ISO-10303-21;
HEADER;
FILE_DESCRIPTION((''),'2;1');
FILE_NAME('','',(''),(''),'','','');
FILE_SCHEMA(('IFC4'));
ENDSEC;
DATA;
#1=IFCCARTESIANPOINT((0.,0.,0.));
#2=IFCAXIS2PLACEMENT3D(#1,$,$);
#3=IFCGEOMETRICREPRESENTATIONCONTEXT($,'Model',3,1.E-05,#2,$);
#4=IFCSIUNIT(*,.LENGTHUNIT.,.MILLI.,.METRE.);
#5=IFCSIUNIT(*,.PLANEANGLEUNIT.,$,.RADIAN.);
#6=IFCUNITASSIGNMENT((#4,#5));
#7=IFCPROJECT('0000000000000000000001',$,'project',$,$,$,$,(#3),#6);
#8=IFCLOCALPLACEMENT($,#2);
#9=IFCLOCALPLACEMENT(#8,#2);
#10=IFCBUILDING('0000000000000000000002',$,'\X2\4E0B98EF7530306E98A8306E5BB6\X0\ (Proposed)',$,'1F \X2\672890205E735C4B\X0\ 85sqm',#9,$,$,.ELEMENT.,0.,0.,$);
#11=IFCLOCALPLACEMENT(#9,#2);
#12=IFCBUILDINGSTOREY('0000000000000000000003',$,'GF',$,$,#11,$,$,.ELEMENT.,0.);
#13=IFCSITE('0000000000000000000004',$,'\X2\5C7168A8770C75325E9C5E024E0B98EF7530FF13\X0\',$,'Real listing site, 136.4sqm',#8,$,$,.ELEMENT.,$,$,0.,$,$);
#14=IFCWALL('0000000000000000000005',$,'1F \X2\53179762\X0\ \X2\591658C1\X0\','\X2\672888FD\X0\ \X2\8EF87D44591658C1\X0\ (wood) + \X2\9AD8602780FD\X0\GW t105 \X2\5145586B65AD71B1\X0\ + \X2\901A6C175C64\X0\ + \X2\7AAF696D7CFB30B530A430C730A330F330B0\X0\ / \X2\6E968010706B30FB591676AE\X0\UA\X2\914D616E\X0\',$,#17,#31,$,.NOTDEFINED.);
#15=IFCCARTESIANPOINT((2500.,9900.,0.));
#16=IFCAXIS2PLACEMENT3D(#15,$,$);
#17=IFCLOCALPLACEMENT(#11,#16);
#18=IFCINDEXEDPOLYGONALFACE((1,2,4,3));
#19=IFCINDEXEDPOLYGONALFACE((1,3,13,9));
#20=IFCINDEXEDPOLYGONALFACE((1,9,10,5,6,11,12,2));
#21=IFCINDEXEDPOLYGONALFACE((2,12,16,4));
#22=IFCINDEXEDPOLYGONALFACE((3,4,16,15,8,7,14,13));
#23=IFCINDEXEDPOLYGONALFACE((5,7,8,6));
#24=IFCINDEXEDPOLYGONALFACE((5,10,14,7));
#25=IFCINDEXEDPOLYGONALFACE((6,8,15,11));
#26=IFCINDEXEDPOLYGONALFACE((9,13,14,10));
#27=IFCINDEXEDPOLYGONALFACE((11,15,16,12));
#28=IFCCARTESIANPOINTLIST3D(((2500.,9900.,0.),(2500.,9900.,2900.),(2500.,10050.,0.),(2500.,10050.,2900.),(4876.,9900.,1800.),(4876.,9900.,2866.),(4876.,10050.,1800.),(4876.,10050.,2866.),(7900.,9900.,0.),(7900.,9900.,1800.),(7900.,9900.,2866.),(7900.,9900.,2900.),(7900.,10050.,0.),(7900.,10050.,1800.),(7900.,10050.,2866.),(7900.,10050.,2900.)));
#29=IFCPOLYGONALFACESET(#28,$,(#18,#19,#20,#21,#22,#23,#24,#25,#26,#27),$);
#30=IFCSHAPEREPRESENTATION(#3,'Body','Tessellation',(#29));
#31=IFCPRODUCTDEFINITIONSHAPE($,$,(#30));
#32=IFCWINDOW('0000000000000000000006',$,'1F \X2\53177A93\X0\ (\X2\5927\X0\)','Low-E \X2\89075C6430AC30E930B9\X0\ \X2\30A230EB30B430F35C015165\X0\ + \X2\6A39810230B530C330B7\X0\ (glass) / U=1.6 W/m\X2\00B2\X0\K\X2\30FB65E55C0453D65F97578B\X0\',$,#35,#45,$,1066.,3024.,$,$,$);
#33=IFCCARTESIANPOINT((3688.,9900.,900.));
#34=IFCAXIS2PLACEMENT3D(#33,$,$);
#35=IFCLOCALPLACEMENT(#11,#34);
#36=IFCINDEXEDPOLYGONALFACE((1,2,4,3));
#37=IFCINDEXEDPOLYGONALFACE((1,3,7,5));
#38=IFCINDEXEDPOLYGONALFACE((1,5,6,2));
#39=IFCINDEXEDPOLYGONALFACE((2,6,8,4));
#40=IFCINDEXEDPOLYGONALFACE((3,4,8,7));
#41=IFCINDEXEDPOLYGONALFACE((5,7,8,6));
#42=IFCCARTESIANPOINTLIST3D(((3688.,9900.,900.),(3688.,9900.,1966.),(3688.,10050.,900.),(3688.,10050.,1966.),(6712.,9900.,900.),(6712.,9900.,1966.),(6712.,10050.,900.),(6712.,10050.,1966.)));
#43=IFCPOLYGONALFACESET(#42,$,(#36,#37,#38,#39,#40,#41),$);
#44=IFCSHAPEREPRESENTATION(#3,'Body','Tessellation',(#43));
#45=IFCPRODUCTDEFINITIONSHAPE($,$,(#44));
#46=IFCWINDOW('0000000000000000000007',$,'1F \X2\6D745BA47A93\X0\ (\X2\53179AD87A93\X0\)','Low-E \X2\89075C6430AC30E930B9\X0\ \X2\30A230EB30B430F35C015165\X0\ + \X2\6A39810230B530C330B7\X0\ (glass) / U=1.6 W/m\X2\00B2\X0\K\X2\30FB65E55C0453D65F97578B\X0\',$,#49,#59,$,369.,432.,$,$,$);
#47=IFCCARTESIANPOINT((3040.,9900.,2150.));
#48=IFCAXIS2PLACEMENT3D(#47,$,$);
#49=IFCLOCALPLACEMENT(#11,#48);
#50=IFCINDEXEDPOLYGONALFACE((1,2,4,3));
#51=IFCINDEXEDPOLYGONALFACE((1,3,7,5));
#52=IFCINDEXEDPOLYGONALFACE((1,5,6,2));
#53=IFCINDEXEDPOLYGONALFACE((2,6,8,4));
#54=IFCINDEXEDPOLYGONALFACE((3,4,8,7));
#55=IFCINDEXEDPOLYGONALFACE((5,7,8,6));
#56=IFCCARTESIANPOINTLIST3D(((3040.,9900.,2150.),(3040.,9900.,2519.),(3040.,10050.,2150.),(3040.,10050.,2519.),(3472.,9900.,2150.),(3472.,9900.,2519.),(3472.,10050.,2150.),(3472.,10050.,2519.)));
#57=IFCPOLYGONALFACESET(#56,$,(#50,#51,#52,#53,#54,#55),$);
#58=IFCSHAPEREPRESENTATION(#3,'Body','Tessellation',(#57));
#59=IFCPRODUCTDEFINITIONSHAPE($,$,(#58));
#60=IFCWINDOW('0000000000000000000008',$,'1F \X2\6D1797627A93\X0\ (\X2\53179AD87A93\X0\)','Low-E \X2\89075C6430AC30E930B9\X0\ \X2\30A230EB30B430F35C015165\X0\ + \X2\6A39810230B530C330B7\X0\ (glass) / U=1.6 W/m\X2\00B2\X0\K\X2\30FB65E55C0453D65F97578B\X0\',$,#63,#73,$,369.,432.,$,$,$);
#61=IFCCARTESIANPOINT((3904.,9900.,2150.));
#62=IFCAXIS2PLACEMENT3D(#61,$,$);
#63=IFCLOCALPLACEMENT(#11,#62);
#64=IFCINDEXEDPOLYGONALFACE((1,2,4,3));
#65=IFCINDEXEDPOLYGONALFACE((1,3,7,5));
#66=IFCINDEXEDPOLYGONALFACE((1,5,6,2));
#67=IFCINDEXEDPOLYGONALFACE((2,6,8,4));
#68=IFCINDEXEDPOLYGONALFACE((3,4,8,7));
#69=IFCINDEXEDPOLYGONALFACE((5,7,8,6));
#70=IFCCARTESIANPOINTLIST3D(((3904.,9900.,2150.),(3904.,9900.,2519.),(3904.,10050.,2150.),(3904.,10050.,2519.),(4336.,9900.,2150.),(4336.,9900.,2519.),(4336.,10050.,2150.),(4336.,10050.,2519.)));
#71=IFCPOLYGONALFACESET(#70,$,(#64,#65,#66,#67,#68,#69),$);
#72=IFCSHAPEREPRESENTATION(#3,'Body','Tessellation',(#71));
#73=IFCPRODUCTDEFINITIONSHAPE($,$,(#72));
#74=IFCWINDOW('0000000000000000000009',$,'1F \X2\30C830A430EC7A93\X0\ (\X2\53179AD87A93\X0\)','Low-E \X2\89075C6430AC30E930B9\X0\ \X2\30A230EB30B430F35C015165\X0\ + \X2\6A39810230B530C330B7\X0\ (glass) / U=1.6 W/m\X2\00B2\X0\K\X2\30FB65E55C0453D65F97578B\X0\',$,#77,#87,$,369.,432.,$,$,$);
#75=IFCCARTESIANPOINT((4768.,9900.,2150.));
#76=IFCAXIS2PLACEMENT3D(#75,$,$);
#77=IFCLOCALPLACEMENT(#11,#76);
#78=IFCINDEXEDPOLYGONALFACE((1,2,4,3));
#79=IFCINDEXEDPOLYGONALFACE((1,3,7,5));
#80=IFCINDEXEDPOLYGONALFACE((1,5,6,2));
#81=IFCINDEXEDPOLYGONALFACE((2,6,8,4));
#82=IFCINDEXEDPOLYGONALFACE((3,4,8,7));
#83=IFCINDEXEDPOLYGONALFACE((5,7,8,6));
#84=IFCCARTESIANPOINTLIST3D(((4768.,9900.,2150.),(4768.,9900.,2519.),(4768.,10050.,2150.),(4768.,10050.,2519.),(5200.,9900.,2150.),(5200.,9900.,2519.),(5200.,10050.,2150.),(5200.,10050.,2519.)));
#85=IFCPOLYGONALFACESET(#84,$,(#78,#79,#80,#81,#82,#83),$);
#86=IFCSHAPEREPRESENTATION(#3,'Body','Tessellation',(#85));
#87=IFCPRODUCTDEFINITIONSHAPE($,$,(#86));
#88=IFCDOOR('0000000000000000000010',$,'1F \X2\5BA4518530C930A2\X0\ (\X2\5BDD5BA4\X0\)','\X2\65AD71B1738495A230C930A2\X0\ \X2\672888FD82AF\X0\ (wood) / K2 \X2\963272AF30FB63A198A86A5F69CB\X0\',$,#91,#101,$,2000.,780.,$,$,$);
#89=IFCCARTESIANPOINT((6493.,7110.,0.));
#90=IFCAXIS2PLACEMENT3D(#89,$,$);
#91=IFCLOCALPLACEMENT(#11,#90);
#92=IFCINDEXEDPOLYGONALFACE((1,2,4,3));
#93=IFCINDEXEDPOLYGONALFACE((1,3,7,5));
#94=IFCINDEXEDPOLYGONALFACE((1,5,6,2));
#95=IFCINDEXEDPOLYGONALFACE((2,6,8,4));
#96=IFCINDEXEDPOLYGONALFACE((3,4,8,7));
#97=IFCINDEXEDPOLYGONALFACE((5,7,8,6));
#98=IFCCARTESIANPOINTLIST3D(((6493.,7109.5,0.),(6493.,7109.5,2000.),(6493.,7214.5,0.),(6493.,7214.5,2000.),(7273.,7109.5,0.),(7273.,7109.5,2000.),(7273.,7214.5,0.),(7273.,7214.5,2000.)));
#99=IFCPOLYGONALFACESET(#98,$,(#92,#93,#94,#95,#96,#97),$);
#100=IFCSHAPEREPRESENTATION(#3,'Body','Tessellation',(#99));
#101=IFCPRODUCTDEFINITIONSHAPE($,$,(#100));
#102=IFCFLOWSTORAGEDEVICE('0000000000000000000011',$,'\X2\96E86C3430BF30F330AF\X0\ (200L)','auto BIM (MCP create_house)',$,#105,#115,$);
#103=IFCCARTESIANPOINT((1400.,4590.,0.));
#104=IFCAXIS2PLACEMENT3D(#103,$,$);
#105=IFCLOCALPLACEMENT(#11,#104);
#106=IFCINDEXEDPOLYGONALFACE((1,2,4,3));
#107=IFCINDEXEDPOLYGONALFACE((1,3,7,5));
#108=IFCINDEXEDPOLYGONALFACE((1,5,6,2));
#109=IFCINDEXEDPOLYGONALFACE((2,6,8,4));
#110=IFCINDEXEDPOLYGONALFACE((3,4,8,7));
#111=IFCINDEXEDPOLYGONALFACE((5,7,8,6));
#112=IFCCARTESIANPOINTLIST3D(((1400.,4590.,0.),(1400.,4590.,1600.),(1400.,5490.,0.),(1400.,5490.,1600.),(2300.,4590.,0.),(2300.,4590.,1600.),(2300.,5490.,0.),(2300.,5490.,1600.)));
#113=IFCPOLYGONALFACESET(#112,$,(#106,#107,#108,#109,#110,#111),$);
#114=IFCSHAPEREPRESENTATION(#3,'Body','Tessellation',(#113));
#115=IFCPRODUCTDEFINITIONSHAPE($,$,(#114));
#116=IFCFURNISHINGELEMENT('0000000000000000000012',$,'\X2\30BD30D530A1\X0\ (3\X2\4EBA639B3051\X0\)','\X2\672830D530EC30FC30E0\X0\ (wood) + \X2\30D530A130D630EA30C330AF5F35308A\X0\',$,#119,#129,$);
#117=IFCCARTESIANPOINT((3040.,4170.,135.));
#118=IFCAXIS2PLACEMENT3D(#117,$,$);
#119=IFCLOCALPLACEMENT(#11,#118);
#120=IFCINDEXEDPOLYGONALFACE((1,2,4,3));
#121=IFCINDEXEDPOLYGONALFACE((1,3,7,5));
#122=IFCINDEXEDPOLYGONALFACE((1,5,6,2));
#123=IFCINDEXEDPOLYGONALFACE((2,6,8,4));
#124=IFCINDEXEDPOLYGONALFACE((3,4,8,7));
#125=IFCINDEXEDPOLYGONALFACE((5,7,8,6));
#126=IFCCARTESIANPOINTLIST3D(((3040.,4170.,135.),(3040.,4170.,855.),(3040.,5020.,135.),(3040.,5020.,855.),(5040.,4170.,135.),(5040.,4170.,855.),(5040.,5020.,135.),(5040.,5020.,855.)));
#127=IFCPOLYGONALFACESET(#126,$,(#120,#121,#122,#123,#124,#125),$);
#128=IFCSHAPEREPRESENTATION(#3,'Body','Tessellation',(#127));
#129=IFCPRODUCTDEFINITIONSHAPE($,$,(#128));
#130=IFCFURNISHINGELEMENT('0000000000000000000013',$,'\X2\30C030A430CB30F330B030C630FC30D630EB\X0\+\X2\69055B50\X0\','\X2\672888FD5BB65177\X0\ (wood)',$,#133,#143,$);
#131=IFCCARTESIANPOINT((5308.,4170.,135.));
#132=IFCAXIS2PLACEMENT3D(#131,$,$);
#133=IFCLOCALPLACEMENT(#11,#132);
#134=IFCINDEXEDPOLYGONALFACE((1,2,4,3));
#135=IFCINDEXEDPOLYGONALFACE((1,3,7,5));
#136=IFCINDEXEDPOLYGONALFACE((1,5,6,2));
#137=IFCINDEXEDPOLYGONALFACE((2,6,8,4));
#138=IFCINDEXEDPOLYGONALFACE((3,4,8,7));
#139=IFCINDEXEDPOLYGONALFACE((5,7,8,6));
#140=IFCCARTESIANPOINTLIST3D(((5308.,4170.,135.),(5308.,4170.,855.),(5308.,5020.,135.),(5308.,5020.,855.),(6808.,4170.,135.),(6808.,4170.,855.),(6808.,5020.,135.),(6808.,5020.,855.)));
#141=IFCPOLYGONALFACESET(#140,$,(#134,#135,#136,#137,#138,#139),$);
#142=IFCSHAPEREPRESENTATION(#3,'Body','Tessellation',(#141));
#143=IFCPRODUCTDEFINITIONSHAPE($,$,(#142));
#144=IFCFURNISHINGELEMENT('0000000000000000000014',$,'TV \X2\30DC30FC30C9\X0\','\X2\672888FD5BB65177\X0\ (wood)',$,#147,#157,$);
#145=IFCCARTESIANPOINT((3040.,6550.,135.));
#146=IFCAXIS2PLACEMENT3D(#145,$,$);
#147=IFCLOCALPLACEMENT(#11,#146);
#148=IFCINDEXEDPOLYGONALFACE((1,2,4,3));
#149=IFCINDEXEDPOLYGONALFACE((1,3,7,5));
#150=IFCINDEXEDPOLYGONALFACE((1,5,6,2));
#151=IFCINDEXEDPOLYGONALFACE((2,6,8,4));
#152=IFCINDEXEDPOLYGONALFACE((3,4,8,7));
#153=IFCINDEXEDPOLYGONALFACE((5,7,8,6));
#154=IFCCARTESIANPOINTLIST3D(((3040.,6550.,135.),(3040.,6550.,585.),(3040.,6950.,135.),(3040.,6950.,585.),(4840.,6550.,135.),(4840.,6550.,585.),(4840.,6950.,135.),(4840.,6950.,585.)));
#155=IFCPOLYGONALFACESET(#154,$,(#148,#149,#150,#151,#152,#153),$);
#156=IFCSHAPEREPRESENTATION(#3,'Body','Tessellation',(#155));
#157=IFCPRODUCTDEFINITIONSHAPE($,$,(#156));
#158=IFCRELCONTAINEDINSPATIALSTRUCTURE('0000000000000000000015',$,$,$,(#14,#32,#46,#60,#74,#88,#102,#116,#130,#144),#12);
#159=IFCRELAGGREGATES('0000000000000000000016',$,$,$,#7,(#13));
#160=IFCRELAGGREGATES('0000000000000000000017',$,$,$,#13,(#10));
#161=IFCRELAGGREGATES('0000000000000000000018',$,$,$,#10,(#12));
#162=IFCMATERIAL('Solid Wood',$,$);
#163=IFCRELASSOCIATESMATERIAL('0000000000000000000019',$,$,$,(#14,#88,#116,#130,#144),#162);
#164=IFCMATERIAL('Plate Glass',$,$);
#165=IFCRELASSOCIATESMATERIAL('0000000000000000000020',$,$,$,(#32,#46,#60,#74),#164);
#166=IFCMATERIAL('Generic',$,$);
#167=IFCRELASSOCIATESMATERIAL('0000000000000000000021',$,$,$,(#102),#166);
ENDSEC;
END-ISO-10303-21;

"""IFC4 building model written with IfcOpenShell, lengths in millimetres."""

from ifc_helpers import new_model, si_unit, frame, frame_2d, origin, place, context, project, spatial, rectangle, extrude, material, element, fill, save


model = new_model("IFC4")

# Units and contexts
model_context = context("Model", 3, precision=1e-05, world=origin())
ifc_project = project(units=[si_unit("LENGTHUNIT", "METRE", prefix="MILLI"), si_unit("PLANEANGLEUNIT", "RADIAN")], contexts=[model_context])

# Site, building, storey
site_placement = place(None, origin())
site = spatial("IfcSite", under=ifc_project, at=site_placement, Name="山梨県甲府市下飯田３", ObjectType="Real listing site, 136.4sqm", CompositionType="ELEMENT", RefElevation=0.0)
building_placement = place(site_placement, origin())
building = spatial("IfcBuilding", under=site, at=building_placement, Name="下飯田の風の家 (Proposed)", ObjectType="1F 木造平屋 85sqm", CompositionType="ELEMENT", ElevationOfRefHeight=0.0, ElevationOfTerrain=0.0)
storey_placement = place(building_placement, origin())
storey = spatial("IfcBuildingStorey", under=building, at=storey_placement, Name="GF", CompositionType="ELEMENT", Elevation=0.0)

# Wall, openings, windows
ifc_material_1 = material(Name="Solid Wood")
wall_1_placement = place(storey_placement, frame((2500.0, 9900.0, 0.0)))
wall_1 = element("IfcWall", 1, at=wall_1_placement, inside=storey, material=ifc_material_1, Name="1F 北面 外壁", Description="木製 軸組外壁 (wood) + 高性能GW t105 充填断熱 + 通気層 + 窯業系サイディング / 準耐火・外皮UA配慮", PredefinedType="NOTDEFINED", context=model_context, shape_type="SweptSolid", body=[
    extrude(rectangle(XDim=5400.0, YDim=150.0, at=frame_2d((2700.0, 75.0))), frame((2500.0, 9900.0, 0.0)), (0.0, 0.0, 1.0), 2900.0),
])
opening_1_placement = place(storey_placement, frame((3688.0, 9900.0, 900.0)))
opening_1 = element("IfcOpeningElement", 2, at=opening_1_placement, cuts=wall_1, PredefinedType="NOTDEFINED", context=model_context, shape_type="SweptSolid", body=[
    extrude(rectangle(XDim=3024.0, YDim=150.0, at=frame_2d((1512.0, 75.0))), frame((3688.0, 9900.0, 900.0)), (0.0, 0.0, 1.0), 1066.0),
])
opening_2_placement = place(storey_placement, frame((3040.0, 9900.0, 2150.0)))
opening_2 = element("IfcOpeningElement", 3, at=opening_2_placement, cuts=wall_1, PredefinedType="NOTDEFINED", context=model_context, shape_type="SweptSolid", body=[
    extrude(rectangle(XDim=432.0, YDim=150.0, at=frame_2d((216.0, 75.0))), frame((3040.0, 9900.0, 2150.0)), (0.0, 0.0, 1.0), 369.0),
])
opening_3_placement = place(storey_placement, frame((3904.0, 9900.0, 2150.0)))
opening_3 = element("IfcOpeningElement", 4, at=opening_3_placement, cuts=wall_1, PredefinedType="NOTDEFINED", context=model_context, shape_type="SweptSolid", body=[
    extrude(rectangle(XDim=432.0, YDim=150.0, at=frame_2d((216.0, 75.0))), frame((3904.0, 9900.0, 2150.0)), (0.0, 0.0, 1.0), 369.0),
])
opening_4_placement = place(storey_placement, frame((4768.0, 9900.0, 2150.0)))
opening_4 = element("IfcOpeningElement", 5, at=opening_4_placement, cuts=wall_1, PredefinedType="NOTDEFINED", context=model_context, shape_type="SweptSolid", body=[
    extrude(rectangle(XDim=432.0, YDim=150.0, at=frame_2d((216.0, 75.0))), frame((4768.0, 9900.0, 2150.0)), (0.0, 0.0, 1.0), 369.0),
])
ifc_material_2 = material(Name="Plate Glass")
window_1_placement = place(storey_placement, frame((3688.0, 9900.0, 900.0)))
window_1 = element("IfcWindow", 6, at=window_1_placement, inside=storey, material=ifc_material_2, Name="1F 北窓 (大)", Description="Low-E 複層ガラス アルゴン封入 + 樹脂サッシ (glass) / U=1.6 W/m²K・日射取得型", OverallHeight=1066.0, OverallWidth=3024.0, context=model_context, shape_type="SweptSolid", body=[
    extrude(rectangle(XDim=3024.0, YDim=150.0, at=frame_2d((1512.0, 75.0))), frame((3688.0, 9900.0, 900.0)), (0.0, 0.0, 1.0), 1066.0),
])
fill(opening_1, window_1)
window_2_placement = place(storey_placement, frame((3040.0, 9900.0, 2150.0)))
window_2 = element("IfcWindow", 7, at=window_2_placement, inside=storey, material=ifc_material_2, Name="1F 浴室窓 (北高窓)", Description="Low-E 複層ガラス アルゴン封入 + 樹脂サッシ (glass) / U=1.6 W/m²K・日射取得型", OverallHeight=369.0, OverallWidth=432.0, context=model_context, shape_type="SweptSolid", body=[
    extrude(rectangle(XDim=432.0, YDim=150.0, at=frame_2d((216.0, 75.0))), frame((3040.0, 9900.0, 2150.0)), (0.0, 0.0, 1.0), 369.0),
])
fill(opening_2, window_2)
window_3_placement = place(storey_placement, frame((3904.0, 9900.0, 2150.0)))
window_3 = element("IfcWindow", 8, at=window_3_placement, inside=storey, material=ifc_material_2, Name="1F 洗面窓 (北高窓)", Description="Low-E 複層ガラス アルゴン封入 + 樹脂サッシ (glass) / U=1.6 W/m²K・日射取得型", OverallHeight=369.0, OverallWidth=432.0, context=model_context, shape_type="SweptSolid", body=[
    extrude(rectangle(XDim=432.0, YDim=150.0, at=frame_2d((216.0, 75.0))), frame((3904.0, 9900.0, 2150.0)), (0.0, 0.0, 1.0), 369.0),
])
fill(opening_3, window_3)
window_4_placement = place(storey_placement, frame((4768.0, 9900.0, 2150.0)))
window_4 = element("IfcWindow", 9, at=window_4_placement, inside=storey, material=ifc_material_2, Name="1F トイレ窓 (北高窓)", Description="Low-E 複層ガラス アルゴン封入 + 樹脂サッシ (glass) / U=1.6 W/m²K・日射取得型", OverallHeight=369.0, OverallWidth=432.0, context=model_context, shape_type="SweptSolid", body=[
    extrude(rectangle(XDim=432.0, YDim=150.0, at=frame_2d((216.0, 75.0))), frame((4768.0, 9900.0, 2150.0)), (0.0, 0.0, 1.0), 369.0),
])
fill(opening_4, window_4)

# Door
door_1_placement = place(storey_placement, frame((6493.0, 7110.0, 0.0)))
element("IfcDoor", 10, at=door_1_placement, inside=storey, material=ifc_material_1, Name="1F 室内ドア (寝室)", Description="断熱玄関ドア 木製芯 (wood) / K2 防犯・採風機構", OverallHeight=2000.0, OverallWidth=780.0, context=model_context, shape_type="SweptSolid", body=[
    extrude(rectangle(XDim=780.0, YDim=105.0, at=frame_2d((390.0, 52.0))), frame((6493.0, 7110.0, 0.0)), (0.0, 0.0, 1.0), 2000.0),
])

# Flow storage device
ifc_material_3 = material(Name="Generic")
flow_storage_device_placement = place(storey_placement, frame((1400.0, 4590.0, 0.0)))
element("IfcFlowStorageDevice", 11, at=flow_storage_device_placement, inside=storey, material=ifc_material_3, Name="雨水タンク (200L)", Description="auto BIM (MCP create_house)", context=model_context, shape_type="SweptSolid", body=[
    extrude(rectangle(XDim=900.0, YDim=900.0, at=frame_2d((450.0, 450.0))), frame((1400.0, 4590.0, 0.0)), (0.0, 0.0, 1.0), 1600.0),
])

# Furnishing elements
furnishing_1_placement = place(storey_placement, frame((3040.0, 4170.0, 135.0)))
element("IfcFurnishingElement", 12, at=furnishing_1_placement, inside=storey, material=ifc_material_1, Name="ソファ (3人掛け)", Description="木フレーム (wood) + ファブリック張り", context=model_context, shape_type="SweptSolid", body=[
    extrude(rectangle(XDim=2000.0, YDim=850.0, at=frame_2d((1000.0, 425.0))), frame((3040.0, 4170.0, 135.0)), (0.0, 0.0, 1.0), 720.0),
])
furnishing_2_placement = place(storey_placement, frame((5308.0, 4170.0, 135.0)))
element("IfcFurnishingElement", 13, at=furnishing_2_placement, inside=storey, material=ifc_material_1, Name="ダイニングテーブル+椅子", Description="木製家具 (wood)", context=model_context, shape_type="SweptSolid", body=[
    extrude(rectangle(XDim=1500.0, YDim=850.0, at=frame_2d((750.0, 425.0))), frame((5308.0, 4170.0, 135.0)), (0.0, 0.0, 1.0), 720.0),
])
furnishing_3_placement = place(storey_placement, frame((3040.0, 6550.0, 135.0)))
element("IfcFurnishingElement", 14, at=furnishing_3_placement, inside=storey, material=ifc_material_1, Name="TV ボード", Description="木製家具 (wood)", context=model_context, shape_type="SweptSolid", body=[
    extrude(rectangle(XDim=1800.0, YDim=400.0, at=frame_2d((900.0, 200.0))), frame((3040.0, 6550.0, 135.0)), (0.0, 0.0, 1.0), 450.0),
])

save(model, "model.ifc")
